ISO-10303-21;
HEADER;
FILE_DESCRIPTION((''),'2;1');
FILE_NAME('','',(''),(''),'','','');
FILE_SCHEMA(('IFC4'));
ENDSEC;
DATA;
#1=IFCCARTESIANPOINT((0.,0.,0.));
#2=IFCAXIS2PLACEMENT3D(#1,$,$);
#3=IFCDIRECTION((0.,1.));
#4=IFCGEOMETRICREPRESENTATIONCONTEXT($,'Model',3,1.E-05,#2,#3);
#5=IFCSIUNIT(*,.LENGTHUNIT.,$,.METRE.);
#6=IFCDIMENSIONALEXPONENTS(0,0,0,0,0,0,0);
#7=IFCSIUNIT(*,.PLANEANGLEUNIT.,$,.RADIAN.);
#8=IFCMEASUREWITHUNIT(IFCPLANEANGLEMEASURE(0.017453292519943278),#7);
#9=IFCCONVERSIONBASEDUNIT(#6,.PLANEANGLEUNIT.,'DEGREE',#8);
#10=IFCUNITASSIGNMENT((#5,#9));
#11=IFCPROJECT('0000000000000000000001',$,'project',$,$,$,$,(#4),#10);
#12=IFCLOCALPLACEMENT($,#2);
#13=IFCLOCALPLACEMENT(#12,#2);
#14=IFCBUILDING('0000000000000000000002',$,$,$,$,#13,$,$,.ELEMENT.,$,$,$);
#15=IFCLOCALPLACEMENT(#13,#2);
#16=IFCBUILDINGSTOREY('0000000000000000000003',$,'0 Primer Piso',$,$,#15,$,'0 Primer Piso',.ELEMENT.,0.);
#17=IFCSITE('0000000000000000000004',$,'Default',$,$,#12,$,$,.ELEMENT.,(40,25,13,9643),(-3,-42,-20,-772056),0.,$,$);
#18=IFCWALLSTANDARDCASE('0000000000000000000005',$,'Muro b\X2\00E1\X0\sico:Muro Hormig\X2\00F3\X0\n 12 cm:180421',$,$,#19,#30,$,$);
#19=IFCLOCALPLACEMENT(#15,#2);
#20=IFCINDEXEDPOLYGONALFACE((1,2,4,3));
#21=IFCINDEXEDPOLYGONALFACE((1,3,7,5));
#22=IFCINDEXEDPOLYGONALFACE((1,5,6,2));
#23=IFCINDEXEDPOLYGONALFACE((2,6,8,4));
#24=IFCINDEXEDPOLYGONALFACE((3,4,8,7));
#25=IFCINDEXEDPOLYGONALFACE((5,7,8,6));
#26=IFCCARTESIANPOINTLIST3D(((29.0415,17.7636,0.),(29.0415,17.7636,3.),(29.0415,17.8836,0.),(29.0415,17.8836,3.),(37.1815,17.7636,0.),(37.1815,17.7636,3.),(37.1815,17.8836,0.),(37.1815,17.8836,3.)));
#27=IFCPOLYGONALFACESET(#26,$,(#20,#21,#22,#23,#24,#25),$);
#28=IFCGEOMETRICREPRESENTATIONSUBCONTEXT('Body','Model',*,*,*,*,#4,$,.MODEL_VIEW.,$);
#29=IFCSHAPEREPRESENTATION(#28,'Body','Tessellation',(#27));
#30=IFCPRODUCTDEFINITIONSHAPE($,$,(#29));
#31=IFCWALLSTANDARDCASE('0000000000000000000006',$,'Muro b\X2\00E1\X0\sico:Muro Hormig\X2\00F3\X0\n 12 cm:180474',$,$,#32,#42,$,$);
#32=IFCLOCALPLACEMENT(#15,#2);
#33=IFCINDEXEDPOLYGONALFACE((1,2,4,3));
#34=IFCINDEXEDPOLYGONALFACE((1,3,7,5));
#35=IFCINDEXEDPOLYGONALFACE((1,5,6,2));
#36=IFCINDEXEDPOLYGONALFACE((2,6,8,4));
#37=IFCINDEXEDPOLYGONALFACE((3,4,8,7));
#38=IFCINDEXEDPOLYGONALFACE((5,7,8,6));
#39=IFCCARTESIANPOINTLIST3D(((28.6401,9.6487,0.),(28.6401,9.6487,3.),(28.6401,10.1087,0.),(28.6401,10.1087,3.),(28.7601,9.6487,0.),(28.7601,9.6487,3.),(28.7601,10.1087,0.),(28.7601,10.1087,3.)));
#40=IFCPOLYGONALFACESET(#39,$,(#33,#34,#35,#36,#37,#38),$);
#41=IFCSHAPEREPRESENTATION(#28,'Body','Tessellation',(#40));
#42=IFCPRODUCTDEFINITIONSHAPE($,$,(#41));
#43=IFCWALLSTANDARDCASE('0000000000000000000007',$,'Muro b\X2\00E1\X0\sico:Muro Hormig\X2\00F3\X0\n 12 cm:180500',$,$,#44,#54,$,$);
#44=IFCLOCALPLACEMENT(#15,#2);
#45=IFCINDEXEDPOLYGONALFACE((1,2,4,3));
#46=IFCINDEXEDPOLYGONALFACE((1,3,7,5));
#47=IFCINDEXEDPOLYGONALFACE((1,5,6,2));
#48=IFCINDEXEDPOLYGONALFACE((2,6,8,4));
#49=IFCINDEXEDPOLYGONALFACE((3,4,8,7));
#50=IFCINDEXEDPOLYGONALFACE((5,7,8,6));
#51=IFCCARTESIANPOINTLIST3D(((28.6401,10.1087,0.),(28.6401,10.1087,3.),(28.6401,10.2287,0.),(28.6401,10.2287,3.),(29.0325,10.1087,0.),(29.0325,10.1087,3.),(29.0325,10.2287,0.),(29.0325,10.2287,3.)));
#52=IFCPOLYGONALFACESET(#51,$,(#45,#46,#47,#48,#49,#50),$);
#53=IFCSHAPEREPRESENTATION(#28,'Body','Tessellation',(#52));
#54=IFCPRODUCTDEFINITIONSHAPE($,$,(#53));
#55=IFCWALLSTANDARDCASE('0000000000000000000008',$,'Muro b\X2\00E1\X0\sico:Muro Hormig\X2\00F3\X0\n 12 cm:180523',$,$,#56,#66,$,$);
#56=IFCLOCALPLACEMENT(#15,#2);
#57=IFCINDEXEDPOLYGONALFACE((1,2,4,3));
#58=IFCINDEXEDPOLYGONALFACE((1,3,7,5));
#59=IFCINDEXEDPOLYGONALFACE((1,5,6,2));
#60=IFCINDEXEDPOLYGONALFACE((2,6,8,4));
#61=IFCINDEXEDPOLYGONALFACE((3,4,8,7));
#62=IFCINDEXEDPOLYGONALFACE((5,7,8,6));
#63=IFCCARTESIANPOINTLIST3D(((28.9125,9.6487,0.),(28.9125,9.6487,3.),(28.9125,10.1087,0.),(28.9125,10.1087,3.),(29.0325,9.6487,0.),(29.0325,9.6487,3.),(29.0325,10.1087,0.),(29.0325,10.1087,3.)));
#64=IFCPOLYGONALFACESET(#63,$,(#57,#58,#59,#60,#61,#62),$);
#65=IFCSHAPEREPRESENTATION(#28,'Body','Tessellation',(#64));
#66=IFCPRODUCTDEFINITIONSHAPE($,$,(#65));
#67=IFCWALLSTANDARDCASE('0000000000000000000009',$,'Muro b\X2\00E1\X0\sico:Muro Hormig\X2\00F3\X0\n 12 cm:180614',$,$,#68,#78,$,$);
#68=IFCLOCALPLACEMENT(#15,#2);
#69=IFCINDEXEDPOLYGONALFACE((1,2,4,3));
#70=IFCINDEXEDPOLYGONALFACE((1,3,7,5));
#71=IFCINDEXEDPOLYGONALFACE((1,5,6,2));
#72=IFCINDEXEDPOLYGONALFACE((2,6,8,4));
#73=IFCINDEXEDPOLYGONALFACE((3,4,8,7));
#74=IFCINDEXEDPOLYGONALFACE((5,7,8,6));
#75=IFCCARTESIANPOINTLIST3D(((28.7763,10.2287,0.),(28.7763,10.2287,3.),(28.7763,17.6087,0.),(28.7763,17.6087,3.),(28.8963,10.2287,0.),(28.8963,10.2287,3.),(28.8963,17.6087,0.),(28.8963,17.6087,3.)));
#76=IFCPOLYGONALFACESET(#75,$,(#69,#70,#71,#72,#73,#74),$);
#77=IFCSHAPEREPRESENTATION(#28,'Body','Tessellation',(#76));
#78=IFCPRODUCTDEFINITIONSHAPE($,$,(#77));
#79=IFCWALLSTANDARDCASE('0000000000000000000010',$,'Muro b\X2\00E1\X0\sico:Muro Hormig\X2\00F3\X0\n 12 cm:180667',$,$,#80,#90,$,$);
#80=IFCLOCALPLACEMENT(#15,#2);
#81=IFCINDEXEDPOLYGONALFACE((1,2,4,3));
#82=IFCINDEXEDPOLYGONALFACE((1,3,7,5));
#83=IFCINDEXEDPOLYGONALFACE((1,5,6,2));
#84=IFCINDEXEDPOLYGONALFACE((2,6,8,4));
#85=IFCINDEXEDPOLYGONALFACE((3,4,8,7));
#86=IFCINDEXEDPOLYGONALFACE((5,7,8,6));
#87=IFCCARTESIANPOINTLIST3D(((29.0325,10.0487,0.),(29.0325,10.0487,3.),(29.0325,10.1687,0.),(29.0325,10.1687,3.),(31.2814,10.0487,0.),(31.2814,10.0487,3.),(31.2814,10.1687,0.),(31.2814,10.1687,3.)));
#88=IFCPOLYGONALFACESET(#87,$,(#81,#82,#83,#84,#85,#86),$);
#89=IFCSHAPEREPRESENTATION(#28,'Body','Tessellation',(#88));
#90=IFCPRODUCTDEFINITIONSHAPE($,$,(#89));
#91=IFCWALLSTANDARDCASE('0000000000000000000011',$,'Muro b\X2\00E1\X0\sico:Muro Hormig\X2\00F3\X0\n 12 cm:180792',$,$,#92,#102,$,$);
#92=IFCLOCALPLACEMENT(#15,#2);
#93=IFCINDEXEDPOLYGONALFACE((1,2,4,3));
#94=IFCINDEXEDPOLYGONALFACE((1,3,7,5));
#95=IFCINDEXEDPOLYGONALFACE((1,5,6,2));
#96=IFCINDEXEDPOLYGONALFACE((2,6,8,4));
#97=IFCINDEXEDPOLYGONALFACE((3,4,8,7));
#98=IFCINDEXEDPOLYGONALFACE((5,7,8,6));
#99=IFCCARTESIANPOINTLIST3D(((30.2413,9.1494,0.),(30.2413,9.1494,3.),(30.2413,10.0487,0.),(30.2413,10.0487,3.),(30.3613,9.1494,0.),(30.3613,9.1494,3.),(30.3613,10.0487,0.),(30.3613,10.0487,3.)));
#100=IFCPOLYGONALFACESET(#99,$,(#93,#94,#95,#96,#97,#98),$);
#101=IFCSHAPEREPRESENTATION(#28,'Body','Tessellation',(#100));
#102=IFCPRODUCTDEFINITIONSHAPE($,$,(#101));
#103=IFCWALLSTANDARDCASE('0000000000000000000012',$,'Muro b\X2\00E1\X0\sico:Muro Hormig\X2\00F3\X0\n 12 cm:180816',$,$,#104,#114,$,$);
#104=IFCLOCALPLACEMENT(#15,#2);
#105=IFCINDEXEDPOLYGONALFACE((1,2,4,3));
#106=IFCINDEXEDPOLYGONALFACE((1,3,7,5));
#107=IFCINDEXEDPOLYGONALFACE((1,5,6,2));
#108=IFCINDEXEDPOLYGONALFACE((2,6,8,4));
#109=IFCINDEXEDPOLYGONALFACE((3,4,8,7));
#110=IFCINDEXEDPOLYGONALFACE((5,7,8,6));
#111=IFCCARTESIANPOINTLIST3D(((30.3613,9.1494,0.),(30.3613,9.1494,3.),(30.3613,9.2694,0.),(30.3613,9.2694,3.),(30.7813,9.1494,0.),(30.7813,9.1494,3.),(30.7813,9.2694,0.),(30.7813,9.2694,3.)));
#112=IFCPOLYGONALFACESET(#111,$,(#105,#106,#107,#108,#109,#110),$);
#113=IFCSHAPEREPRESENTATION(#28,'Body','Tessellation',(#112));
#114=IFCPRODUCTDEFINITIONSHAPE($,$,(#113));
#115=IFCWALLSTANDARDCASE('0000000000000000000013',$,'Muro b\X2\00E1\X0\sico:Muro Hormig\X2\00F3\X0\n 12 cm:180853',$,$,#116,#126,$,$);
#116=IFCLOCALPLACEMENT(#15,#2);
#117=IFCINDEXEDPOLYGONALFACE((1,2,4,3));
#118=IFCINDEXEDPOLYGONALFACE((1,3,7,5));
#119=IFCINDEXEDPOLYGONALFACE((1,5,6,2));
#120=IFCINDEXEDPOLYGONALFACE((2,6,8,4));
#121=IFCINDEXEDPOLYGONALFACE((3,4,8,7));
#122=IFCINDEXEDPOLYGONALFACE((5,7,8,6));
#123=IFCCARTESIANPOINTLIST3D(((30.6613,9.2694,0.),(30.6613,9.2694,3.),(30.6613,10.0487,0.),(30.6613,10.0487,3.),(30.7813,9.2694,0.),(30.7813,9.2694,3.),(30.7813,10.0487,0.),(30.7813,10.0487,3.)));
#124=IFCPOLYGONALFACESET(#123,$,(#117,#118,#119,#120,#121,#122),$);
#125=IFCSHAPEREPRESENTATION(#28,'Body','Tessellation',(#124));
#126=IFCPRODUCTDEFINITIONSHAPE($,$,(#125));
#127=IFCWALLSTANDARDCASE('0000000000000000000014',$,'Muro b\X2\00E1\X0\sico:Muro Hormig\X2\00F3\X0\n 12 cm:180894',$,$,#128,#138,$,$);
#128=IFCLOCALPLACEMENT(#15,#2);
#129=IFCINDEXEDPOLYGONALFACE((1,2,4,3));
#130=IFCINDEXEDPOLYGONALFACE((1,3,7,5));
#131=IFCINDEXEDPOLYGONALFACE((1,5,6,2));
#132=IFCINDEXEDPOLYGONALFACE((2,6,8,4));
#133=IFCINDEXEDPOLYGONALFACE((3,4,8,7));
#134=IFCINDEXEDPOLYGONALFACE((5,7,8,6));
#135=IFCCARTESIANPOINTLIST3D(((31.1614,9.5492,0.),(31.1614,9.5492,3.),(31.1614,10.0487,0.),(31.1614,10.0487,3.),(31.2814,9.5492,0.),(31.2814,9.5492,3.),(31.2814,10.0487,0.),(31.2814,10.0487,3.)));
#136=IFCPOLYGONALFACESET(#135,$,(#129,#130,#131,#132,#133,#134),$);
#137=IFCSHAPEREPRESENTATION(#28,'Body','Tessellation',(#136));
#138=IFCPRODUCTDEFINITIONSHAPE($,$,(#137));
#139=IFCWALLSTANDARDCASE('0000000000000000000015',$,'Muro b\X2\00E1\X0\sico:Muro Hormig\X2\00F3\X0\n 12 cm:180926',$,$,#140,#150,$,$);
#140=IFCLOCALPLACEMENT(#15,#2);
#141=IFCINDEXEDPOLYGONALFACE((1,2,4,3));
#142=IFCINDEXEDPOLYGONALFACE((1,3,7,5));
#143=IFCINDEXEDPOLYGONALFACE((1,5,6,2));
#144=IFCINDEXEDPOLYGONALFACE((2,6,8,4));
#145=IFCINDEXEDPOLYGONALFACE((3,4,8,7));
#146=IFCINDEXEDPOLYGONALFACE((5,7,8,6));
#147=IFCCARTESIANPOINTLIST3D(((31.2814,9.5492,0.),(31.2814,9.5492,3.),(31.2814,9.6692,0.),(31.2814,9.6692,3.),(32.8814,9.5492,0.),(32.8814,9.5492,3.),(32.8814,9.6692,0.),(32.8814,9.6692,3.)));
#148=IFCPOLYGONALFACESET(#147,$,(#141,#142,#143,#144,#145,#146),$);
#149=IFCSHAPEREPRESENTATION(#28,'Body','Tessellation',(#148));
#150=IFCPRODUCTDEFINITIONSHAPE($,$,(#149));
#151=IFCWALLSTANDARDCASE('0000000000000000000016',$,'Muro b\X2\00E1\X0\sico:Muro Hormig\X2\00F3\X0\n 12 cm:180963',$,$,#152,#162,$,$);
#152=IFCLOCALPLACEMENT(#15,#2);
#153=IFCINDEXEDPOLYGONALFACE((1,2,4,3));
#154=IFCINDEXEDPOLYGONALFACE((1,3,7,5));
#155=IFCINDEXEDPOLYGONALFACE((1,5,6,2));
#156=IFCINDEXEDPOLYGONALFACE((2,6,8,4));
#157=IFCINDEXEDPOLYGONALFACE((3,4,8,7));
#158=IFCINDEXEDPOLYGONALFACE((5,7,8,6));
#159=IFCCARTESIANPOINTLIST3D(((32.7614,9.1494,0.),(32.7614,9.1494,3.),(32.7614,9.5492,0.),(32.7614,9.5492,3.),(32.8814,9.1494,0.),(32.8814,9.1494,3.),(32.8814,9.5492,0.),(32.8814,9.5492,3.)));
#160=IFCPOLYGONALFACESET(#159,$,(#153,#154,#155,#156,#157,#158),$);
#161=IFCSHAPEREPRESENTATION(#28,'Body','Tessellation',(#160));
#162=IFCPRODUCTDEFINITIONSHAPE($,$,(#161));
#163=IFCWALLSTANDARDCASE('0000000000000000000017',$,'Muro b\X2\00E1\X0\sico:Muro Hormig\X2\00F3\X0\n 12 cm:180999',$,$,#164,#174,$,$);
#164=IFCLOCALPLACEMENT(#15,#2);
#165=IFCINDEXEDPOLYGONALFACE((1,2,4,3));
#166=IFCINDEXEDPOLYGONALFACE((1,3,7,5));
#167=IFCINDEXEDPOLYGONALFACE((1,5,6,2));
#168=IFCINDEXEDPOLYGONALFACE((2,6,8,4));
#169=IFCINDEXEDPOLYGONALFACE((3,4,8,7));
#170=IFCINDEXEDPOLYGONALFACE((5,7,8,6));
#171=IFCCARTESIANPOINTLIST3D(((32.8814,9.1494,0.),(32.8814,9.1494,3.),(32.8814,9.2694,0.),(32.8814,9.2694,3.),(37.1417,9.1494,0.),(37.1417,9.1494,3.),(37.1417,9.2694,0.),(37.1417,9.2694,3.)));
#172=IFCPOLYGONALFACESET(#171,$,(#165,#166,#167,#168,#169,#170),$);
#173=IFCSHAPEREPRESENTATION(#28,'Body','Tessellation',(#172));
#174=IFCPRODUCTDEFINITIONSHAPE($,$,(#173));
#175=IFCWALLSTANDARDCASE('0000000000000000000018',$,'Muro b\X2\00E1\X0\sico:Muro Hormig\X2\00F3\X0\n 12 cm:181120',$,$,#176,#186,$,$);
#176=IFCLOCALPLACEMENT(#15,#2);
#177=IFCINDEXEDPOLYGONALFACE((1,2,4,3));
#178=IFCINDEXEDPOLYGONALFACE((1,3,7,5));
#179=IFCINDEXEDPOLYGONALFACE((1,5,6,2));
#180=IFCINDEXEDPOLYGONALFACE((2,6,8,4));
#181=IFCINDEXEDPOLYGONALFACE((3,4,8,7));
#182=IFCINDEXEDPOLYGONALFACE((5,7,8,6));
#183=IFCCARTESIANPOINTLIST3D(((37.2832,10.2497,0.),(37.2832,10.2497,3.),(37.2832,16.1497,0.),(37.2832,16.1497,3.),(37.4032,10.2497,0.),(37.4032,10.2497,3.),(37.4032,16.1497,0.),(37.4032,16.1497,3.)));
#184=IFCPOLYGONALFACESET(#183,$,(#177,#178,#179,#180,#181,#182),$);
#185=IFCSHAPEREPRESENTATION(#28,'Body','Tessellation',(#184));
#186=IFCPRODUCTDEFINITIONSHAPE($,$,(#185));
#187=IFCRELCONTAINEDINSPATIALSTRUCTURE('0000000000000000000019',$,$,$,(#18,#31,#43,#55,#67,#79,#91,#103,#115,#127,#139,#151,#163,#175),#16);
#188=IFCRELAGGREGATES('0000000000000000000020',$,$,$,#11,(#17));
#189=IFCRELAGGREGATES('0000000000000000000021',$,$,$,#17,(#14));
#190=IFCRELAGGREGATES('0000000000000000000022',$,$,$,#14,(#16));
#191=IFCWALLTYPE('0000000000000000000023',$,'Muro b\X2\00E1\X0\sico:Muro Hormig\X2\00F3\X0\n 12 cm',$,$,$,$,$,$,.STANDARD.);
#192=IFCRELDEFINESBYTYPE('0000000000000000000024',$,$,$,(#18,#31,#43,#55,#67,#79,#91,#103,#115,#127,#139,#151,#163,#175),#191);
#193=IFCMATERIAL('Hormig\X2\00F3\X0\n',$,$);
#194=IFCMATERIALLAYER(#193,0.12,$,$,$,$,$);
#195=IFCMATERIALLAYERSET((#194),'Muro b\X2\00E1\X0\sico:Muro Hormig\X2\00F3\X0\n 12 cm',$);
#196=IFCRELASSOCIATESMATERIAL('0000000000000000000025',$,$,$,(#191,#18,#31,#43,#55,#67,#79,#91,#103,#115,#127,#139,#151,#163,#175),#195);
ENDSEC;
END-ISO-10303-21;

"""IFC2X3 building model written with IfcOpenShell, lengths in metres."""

from ifc_helpers import new_model, entity, si_unit, converted_unit, direction, frame, frame_2d, origin, place, context, subcontext, project, spatial, rectangle, extrude, material, layer, layer_set, layer_usage, type_object, element, save


model = new_model("IFC2X3")

# Units and contexts
model_context = context("Model", 3, precision=1e-05, world=origin(), true_north=direction((0.0, 1.0)))
body_context = subcontext(model_context, "Body", "Model", "MODEL_VIEW")
ifc_project = project(units=[si_unit("LENGTHUNIT", "METRE"), converted_unit("PLANEANGLEUNIT", "DEGREE", entity("IfcPlaneAngleMeasure", 0.017453292519943278), si_unit("PLANEANGLEUNIT", "RADIAN"), dimensions=[0, 0, 0, 0, 0, 0, 0])], contexts=[model_context])

# Site, building, storey
site_placement = place(None, origin())
site = spatial("IfcSite", under=ifc_project, at=site_placement, Name="Default", CompositionType="ELEMENT", RefLatitude=(40, 25, 13, 9643), RefLongitude=(-3, -42, -20, -772056), RefElevation=0.0)
building_placement = place(site_placement, origin())
building = spatial("IfcBuilding", under=site, at=building_placement, CompositionType="ELEMENT")
storey_placement = place(building_placement, origin())
storey = spatial("IfcBuildingStorey", under=building, at=storey_placement, Name="0 Primer Piso", LongName="0 Primer Piso", CompositionType="ELEMENT", Elevation=0.0)

# Walls
ifc_material = material(Name="Hormigón")
ifc_layer = layer(ifc_material, 0.12)
ifc_layer_set = layer_set([ifc_layer], Name="Muro básico:Muro Hormigón 12 cm")
ifc_layer_usage_1 = layer_usage(ifc_layer_set, "AXIS2", "NEGATIVE", 0.06)
wall_type = type_object("IfcWallType", Name="Muro básico:Muro Hormigón 12 cm", PredefinedType="STANDARD", material=ifc_layer_set)
wall_1_placement = place(storey_placement, frame((29.0415, 17.8236, 0.0)))
element("IfcWallStandardCase", 1, at=wall_1_placement, inside=storey, type_object=wall_type, material=ifc_layer_usage_1, Name="Muro básico:Muro Hormigón 12 cm:180421", context=body_context, shape_type="SweptSolid", body=[
    extrude(rectangle(XDim=8.14, YDim=0.12, at=frame_2d((4.07, 0.0), x_axis=(-1.0, 0.0))), origin(), (0.0, 0.0, 1.0), 3.0),
])
ifc_layer_usage_2 = layer_usage(ifc_layer_set, "AXIS2", "NEGATIVE", 0.06)
wall_2_placement = place(storey_placement, frame((28.7001, 9.6487, 0.0), z_axis=(0.0, 0.0, 1.0), x_axis=(0.0, 1.0, 0.0)))
element("IfcWallStandardCase", 2, at=wall_2_placement, inside=storey, type_object=wall_type, material=ifc_layer_usage_2, Name="Muro básico:Muro Hormigón 12 cm:180474", context=body_context, shape_type="SweptSolid", body=[
    extrude(rectangle(XDim=0.46, YDim=0.12, at=frame_2d((0.23, 0.0), x_axis=(-1.0, 0.0))), origin(), (0.0, 0.0, 1.0), 3.0),
])
ifc_layer_usage_3 = layer_usage(ifc_layer_set, "AXIS2", "NEGATIVE", 0.06)
wall_3_placement = place(storey_placement, frame((28.6401, 10.1687, 0.0)))
element("IfcWallStandardCase", 3, at=wall_3_placement, inside=storey, type_object=wall_type, material=ifc_layer_usage_3, Name="Muro básico:Muro Hormigón 12 cm:180500", context=body_context, shape_type="SweptSolid", body=[
    extrude(rectangle(XDim=0.3924, YDim=0.12, at=frame_2d((0.1962, 0.0), x_axis=(-1.0, 0.0))), origin(), (0.0, 0.0, 1.0), 3.0),
])
ifc_layer_usage_4 = layer_usage(ifc_layer_set, "AXIS2", "NEGATIVE", 0.06)
wall_4_placement = place(storey_placement, frame((28.9725, 10.1087, 0.0), z_axis=(0.0, 0.0, 1.0), x_axis=(0.0, -1.0, 0.0)))
element("IfcWallStandardCase", 4, at=wall_4_placement, inside=storey, type_object=wall_type, material=ifc_layer_usage_4, Name="Muro básico:Muro Hormigón 12 cm:180523", context=body_context, shape_type="SweptSolid", body=[
    extrude(rectangle(XDim=0.46, YDim=0.12, at=frame_2d((0.23, 0.0), x_axis=(-1.0, 0.0))), origin(), (0.0, 0.0, 1.0), 3.0),
])
ifc_layer_usage_5 = layer_usage(ifc_layer_set, "AXIS2", "NEGATIVE", 0.06)
wall_5_placement = place(storey_placement, frame((28.8363, 10.2287, 0.0), z_axis=(0.0, 0.0, 1.0), x_axis=(0.0, 1.0, 0.0)))
element("IfcWallStandardCase", 5, at=wall_5_placement, inside=storey, type_object=wall_type, material=ifc_layer_usage_5, Name="Muro básico:Muro Hormigón 12 cm:180614", context=body_context, shape_type="SweptSolid", body=[
    extrude(rectangle(XDim=7.38, YDim=0.12, at=frame_2d((3.69, 0.0), x_axis=(-1.0, 0.0))), origin(), (0.0, 0.0, 1.0), 3.0),
])
ifc_layer_usage_6 = layer_usage(ifc_layer_set, "AXIS2", "NEGATIVE", 0.06)
wall_6_placement = place(storey_placement, frame((29.0325, 10.1087, 0.0)))
element("IfcWallStandardCase", 6, at=wall_6_placement, inside=storey, type_object=wall_type, material=ifc_layer_usage_6, Name="Muro básico:Muro Hormigón 12 cm:180667", context=body_context, shape_type="SweptSolid", body=[
    extrude(rectangle(XDim=2.2489, YDim=0.12, at=frame_2d((1.1244, 0.0), x_axis=(-1.0, 0.0))), origin(), (0.0, 0.0, 1.0), 3.0),
])
ifc_layer_usage_7 = layer_usage(ifc_layer_set, "AXIS2", "NEGATIVE", 0.06)
wall_7_placement = place(storey_placement, frame((30.3013, 10.0487, 0.0), z_axis=(0.0, 0.0, 1.0), x_axis=(0.0, -1.0, 0.0)))
element("IfcWallStandardCase", 7, at=wall_7_placement, inside=storey, type_object=wall_type, material=ifc_layer_usage_7, Name="Muro básico:Muro Hormigón 12 cm:180792", context=body_context, shape_type="SweptSolid", body=[
    extrude(rectangle(XDim=0.8994, YDim=0.12, at=frame_2d((0.4497, 0.0), x_axis=(-1.0, 0.0))), origin(), (0.0, 0.0, 1.0), 3.0),
])
ifc_layer_usage_8 = layer_usage(ifc_layer_set, "AXIS2", "NEGATIVE", 0.06)
wall_8_placement = place(storey_placement, frame((30.3613, 9.2094, 0.0)))
element("IfcWallStandardCase", 8, at=wall_8_placement, inside=storey, type_object=wall_type, material=ifc_layer_usage_8, Name="Muro básico:Muro Hormigón 12 cm:180816", context=body_context, shape_type="SweptSolid", body=[
    extrude(rectangle(XDim=0.42, YDim=0.12, at=frame_2d((0.21, 0.0), x_axis=(-1.0, 0.0))), origin(), (0.0, 0.0, 1.0), 3.0),
])
ifc_layer_usage_9 = layer_usage(ifc_layer_set, "AXIS2", "NEGATIVE", 0.06)
wall_9_placement = place(storey_placement, frame((30.7213, 9.2694, 0.0), z_axis=(0.0, 0.0, 1.0), x_axis=(0.0, 1.0, 0.0)))
element("IfcWallStandardCase", 9, at=wall_9_placement, inside=storey, type_object=wall_type, material=ifc_layer_usage_9, Name="Muro básico:Muro Hormigón 12 cm:180853", context=body_context, shape_type="SweptSolid", body=[
    extrude(rectangle(XDim=0.7794, YDim=0.12, at=frame_2d((0.3897, 0.0), x_axis=(-1.0, 0.0))), origin(), (0.0, 0.0, 1.0), 3.0),
])
ifc_layer_usage_10 = layer_usage(ifc_layer_set, "AXIS2", "NEGATIVE", 0.06)
wall_10_placement = place(storey_placement, frame((31.2214, 10.0487, 0.0), z_axis=(0.0, 0.0, 1.0), x_axis=(0.0, -1.0, 0.0)))
element("IfcWallStandardCase", 10, at=wall_10_placement, inside=storey, type_object=wall_type, material=ifc_layer_usage_10, Name="Muro básico:Muro Hormigón 12 cm:180894", context=body_context, shape_type="SweptSolid", body=[
    extrude(rectangle(XDim=0.4995, YDim=0.12, at=frame_2d((0.2498, 0.0), x_axis=(-1.0, 0.0))), origin(), (0.0, 0.0, 1.0), 3.0),
])
ifc_layer_usage_11 = layer_usage(ifc_layer_set, "AXIS2", "NEGATIVE", 0.06)
wall_11_placement = place(storey_placement, frame((31.2814, 9.6092, 0.0)))
element("IfcWallStandardCase", 11, at=wall_11_placement, inside=storey, type_object=wall_type, material=ifc_layer_usage_11, Name="Muro básico:Muro Hormigón 12 cm:180926", context=body_context, shape_type="SweptSolid", body=[
    extrude(rectangle(XDim=1.6, YDim=0.12, at=frame_2d((0.8, 0.0), x_axis=(-1.0, 0.0))), origin(), (0.0, 0.0, 1.0), 3.0),
])
ifc_layer_usage_12 = layer_usage(ifc_layer_set, "AXIS2", "NEGATIVE", 0.06)
wall_12_placement = place(storey_placement, frame((32.8214, 9.5492, 0.0), z_axis=(0.0, 0.0, 1.0), x_axis=(0.0, -1.0, 0.0)))
element("IfcWallStandardCase", 12, at=wall_12_placement, inside=storey, type_object=wall_type, material=ifc_layer_usage_12, Name="Muro básico:Muro Hormigón 12 cm:180963", context=body_context, shape_type="SweptSolid", body=[
    extrude(rectangle(XDim=0.3998, YDim=0.12, at=frame_2d((0.1999, 0.0), x_axis=(-1.0, 0.0))), origin(), (0.0, 0.0, 1.0), 3.0),
])
ifc_layer_usage_13 = layer_usage(ifc_layer_set, "AXIS2", "NEGATIVE", 0.06)
wall_13_placement = place(storey_placement, frame((32.8814, 9.2094, 0.0)))
element("IfcWallStandardCase", 13, at=wall_13_placement, inside=storey, type_object=wall_type, material=ifc_layer_usage_13, Name="Muro básico:Muro Hormigón 12 cm:180999", context=body_context, shape_type="SweptSolid", body=[
    extrude(rectangle(XDim=4.2603, YDim=0.12, at=frame_2d((2.1301, 0.0), x_axis=(-1.0, 0.0))), origin(), (0.0, 0.0, 1.0), 3.0),
])
ifc_layer_usage_14 = layer_usage(ifc_layer_set, "AXIS2", "NEGATIVE", 0.06)
wall_14_placement = place(storey_placement, frame((37.3432, 16.1497, 0.0), z_axis=(0.0, 0.0, 1.0), x_axis=(0.0, -1.0, 0.0)))
element("IfcWallStandardCase", 14, at=wall_14_placement, inside=storey, type_object=wall_type, material=ifc_layer_usage_14, Name="Muro básico:Muro Hormigón 12 cm:181120", context=body_context, shape_type="SweptSolid", body=[
    extrude(rectangle(XDim=5.9, YDim=0.12, at=frame_2d((2.95, 0.0), x_axis=(-1.0, 0.0))), origin(), (0.0, 0.0, 1.0), 3.0),
])

save(model, "model.ifc")
